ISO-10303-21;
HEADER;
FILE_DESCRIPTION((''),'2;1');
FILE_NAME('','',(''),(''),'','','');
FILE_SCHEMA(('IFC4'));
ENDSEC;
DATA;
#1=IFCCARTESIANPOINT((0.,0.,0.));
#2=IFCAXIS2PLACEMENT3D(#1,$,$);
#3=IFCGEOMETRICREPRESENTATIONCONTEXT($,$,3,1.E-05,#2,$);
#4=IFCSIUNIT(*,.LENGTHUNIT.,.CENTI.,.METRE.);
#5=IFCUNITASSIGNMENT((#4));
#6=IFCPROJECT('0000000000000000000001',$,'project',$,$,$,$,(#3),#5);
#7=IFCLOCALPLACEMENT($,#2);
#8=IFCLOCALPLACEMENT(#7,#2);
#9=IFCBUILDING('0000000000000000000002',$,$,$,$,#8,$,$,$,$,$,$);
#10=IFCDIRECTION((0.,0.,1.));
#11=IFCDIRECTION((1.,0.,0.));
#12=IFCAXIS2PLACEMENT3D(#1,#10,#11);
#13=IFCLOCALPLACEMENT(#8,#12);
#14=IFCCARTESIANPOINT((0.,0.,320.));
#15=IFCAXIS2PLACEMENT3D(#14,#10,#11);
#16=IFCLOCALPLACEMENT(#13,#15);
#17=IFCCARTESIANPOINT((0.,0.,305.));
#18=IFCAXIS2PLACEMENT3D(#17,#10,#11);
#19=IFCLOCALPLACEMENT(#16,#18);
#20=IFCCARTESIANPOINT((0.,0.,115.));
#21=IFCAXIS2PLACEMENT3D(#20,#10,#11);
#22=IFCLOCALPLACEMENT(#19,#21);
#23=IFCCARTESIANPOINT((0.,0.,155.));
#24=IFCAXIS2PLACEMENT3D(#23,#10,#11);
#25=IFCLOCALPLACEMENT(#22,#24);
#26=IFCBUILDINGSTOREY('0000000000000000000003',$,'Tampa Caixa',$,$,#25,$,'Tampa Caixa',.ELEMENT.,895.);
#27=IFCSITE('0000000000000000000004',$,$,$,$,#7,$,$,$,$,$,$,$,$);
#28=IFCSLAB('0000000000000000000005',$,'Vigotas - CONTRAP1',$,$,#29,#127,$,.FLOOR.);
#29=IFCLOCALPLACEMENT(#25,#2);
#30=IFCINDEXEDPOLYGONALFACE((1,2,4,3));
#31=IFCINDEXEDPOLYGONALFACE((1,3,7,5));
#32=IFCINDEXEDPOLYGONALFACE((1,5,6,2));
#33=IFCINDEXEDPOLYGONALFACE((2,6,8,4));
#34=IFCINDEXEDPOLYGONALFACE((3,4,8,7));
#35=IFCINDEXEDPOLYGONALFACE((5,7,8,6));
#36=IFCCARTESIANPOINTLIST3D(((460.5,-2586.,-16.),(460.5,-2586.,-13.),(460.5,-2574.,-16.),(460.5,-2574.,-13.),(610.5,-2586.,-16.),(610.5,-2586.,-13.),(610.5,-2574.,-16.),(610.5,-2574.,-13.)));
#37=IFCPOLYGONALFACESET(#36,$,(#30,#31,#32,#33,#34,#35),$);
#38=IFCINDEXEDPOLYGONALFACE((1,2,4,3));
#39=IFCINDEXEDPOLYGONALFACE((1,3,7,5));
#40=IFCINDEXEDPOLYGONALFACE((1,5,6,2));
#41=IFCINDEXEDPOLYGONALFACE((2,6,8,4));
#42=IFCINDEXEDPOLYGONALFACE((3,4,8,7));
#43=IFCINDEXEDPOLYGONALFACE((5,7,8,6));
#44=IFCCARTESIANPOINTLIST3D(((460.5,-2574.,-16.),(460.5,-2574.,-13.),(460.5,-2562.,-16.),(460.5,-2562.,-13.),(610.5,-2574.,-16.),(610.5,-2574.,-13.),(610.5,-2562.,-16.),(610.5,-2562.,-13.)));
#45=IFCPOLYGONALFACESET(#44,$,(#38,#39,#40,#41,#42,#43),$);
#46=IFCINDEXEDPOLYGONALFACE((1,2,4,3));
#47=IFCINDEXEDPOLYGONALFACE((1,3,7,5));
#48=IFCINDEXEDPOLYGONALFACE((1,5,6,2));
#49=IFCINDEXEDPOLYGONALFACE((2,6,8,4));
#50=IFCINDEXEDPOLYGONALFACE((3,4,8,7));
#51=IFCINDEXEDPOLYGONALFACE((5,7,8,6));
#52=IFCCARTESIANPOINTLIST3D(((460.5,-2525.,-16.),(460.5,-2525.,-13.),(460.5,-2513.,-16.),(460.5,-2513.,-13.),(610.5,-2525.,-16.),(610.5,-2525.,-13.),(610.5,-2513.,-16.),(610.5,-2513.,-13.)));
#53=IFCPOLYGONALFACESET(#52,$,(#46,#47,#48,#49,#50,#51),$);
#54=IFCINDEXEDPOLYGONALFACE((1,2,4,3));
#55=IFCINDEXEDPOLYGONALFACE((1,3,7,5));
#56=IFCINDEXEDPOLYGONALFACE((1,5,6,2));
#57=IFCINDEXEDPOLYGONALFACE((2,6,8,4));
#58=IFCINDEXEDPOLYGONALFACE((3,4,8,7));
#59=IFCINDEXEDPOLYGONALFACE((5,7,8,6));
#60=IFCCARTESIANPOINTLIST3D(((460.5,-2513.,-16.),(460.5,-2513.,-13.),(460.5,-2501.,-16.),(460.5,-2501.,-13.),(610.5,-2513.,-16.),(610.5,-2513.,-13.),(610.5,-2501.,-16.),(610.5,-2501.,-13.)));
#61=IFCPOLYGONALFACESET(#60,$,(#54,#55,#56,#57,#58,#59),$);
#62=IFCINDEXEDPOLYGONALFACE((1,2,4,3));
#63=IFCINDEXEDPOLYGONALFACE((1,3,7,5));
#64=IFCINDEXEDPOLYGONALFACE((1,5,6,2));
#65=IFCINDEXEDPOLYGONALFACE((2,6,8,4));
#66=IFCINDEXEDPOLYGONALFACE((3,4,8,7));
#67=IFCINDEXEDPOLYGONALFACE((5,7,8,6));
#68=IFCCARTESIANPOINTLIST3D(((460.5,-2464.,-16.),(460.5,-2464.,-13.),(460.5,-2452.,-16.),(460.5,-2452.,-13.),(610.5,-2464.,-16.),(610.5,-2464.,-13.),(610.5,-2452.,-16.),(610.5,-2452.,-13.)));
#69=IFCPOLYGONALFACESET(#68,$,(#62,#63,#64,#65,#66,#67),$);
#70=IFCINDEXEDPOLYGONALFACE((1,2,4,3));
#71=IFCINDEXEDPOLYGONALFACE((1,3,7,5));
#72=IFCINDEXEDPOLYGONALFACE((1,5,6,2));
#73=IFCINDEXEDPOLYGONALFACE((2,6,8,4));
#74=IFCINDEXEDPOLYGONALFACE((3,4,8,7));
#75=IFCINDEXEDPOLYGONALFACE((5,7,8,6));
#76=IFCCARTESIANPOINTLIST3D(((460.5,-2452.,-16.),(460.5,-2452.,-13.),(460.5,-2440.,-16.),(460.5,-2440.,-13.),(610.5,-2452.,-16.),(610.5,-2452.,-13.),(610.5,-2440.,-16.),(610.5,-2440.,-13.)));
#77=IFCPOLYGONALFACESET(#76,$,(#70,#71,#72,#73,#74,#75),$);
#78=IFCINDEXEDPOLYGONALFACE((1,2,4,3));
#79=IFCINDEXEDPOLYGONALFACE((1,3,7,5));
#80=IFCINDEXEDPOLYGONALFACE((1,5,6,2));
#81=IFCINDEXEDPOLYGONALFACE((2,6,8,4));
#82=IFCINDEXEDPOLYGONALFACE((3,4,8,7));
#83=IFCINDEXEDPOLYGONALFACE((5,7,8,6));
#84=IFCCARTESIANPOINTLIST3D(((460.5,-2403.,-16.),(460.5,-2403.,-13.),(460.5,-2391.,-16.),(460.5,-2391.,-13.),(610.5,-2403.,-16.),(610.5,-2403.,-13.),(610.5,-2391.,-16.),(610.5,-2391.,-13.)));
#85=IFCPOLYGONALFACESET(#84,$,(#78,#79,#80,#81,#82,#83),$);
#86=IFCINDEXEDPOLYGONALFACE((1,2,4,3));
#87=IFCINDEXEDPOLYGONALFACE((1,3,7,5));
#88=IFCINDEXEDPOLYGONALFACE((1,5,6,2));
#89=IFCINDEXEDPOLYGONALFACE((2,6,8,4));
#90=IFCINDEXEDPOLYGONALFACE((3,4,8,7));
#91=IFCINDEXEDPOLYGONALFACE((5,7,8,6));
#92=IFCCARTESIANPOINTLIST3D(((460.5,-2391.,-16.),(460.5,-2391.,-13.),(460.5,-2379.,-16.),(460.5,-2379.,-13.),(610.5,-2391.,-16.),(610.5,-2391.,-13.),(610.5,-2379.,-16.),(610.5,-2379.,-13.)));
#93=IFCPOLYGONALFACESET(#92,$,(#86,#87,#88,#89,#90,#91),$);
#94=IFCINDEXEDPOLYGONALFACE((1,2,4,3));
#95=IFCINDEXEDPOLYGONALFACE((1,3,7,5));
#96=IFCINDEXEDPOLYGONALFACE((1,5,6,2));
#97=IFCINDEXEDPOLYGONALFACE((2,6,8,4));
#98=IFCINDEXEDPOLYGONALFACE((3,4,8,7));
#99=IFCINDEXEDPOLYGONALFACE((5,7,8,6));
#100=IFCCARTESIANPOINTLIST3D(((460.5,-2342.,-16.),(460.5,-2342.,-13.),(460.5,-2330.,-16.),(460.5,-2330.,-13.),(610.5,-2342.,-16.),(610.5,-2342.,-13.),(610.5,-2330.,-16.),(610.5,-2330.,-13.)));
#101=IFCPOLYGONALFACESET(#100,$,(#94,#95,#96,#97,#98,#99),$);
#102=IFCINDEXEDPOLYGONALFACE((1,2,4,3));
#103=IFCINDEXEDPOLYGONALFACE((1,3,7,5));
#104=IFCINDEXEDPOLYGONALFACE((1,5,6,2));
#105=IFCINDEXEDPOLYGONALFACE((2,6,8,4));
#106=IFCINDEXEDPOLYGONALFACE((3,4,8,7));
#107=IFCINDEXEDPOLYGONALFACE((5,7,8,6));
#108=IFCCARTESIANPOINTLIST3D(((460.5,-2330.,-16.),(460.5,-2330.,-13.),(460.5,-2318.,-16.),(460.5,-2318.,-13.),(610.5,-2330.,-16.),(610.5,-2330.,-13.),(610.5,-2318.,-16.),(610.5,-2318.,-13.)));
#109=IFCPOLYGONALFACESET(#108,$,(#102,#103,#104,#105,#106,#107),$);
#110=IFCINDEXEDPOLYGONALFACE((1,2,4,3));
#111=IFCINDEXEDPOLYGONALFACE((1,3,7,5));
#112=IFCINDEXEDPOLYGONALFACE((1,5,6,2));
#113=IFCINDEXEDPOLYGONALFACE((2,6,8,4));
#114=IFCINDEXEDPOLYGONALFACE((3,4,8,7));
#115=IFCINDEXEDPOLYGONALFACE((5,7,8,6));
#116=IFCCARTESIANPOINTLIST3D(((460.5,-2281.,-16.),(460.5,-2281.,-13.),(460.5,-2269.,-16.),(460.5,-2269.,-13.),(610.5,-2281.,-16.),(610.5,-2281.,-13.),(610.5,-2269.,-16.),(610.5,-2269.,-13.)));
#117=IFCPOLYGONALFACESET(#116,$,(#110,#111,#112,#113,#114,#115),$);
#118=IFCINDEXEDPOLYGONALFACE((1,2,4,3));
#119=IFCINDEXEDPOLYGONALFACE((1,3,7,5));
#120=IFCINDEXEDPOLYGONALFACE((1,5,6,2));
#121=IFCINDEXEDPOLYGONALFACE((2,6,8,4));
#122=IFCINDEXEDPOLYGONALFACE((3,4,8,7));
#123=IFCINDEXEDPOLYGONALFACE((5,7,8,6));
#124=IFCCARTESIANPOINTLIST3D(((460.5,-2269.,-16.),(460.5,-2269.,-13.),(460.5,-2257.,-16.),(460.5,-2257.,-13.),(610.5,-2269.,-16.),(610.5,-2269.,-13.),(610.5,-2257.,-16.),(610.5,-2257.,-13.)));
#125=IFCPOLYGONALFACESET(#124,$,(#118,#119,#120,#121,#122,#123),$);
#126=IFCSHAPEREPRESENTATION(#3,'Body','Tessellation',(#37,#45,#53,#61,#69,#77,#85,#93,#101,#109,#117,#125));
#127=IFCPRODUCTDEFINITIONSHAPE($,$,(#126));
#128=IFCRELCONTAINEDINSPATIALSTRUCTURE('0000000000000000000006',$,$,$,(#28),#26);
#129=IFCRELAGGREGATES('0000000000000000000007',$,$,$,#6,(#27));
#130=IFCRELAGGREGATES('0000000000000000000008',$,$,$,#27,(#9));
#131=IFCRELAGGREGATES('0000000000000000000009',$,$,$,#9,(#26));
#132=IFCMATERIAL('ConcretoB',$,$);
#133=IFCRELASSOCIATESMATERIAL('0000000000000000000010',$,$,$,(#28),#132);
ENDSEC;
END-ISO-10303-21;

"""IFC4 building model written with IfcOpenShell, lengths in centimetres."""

from ifc_helpers import new_model, si_unit, frame, origin, origin_with_axes, place, context, project, spatial, polyline, outline, extrude, material, element, save


model = new_model("IFC4")

# Units and contexts
context_of_model = context(None, 3, precision=1e-05, world=origin())
ifc_project = project(units=[si_unit("LENGTHUNIT", "METRE", prefix="CENTI")], contexts=[context_of_model])

# Site, building, storey
site_placement = place(None, origin())
site = spatial("IfcSite", under=ifc_project, at=site_placement)
building_placement = place(site_placement, origin())
building = spatial("IfcBuilding", under=site, at=building_placement)
placement_1 = place(building_placement, origin_with_axes())
placement_2 = place(placement_1, frame((0.0, 0.0, 320.0), z_axis=(0.0, 0.0, 1.0), x_axis=(1.0, 0.0, 0.0)))
placement_3 = place(placement_2, frame((0.0, 0.0, 305.0), z_axis=(0.0, 0.0, 1.0), x_axis=(1.0, 0.0, 0.0)))
placement_4 = place(placement_3, frame((0.0, 0.0, 115.0), z_axis=(0.0, 0.0, 1.0), x_axis=(1.0, 0.0, 0.0)))
storey_placement = place(placement_4, frame((0.0, 0.0, 155.0), z_axis=(0.0, 0.0, 1.0), x_axis=(1.0, 0.0, 0.0)))
storey = spatial("IfcBuildingStorey", under=building, at=storey_placement, Name="Tampa Caixa", LongName="Tampa Caixa", CompositionType="ELEMENT", Elevation=895.0)

# Shared definitions
ifc_material = material(Name="ConcretoB")

# Slab
slab_placement = place(storey_placement, frame((535.5, -2421.5, -13.0), z_axis=(0.0, 0.0, 1.0), x_axis=(1.0, 0.0, 0.0)))
element("IfcSlab", 1, at=slab_placement, inside=storey, material=ifc_material, Name="Vigotas - CONTRAP1", PredefinedType="FLOOR", context=context_of_model, shape_type="SolidModel", body=[
    extrude(outline(polyline([(6.0, 1.5), (-6.0, 1.5), (-6.0, -1.5), (6.0, -1.5), (6.0, 1.5), (6.0, 1.5)])), frame((-75.0, -158.5, -1.5), z_axis=(1.0, 0.0, 0.0), x_axis=(0.0, -1.0, 0.0)), (0.0, 0.0, 1.0), 150.0),
    extrude(outline(polyline([(6.0, 1.5), (-6.0, 1.5), (-6.0, -1.5), (6.0, -1.5), (6.0, 1.5), (6.0, 1.5)])), frame((-75.0, -146.5, -1.5), z_axis=(1.0, 0.0, 0.0), x_axis=(0.0, -1.0, 0.0)), (0.0, 0.0, 1.0), 150.0),
    extrude(outline(polyline([(6.0, 1.5), (-6.0, 1.5), (-6.0, -1.5), (6.0, -1.5), (6.0, 1.5), (6.0, 1.5)])), frame((-75.0, -97.5, -1.5), z_axis=(1.0, 0.0, 0.0), x_axis=(0.0, -1.0, 0.0)), (0.0, 0.0, 1.0), 150.0),
    extrude(outline(polyline([(6.0, 1.5), (-6.0, 1.5), (-6.0, -1.5), (6.0, -1.5), (6.0, 1.5), (6.0, 1.5)])), frame((-75.0, -85.5, -1.5), z_axis=(1.0, 0.0, 0.0), x_axis=(0.0, -1.0, 0.0)), (0.0, 0.0, 1.0), 150.0),
    extrude(outline(polyline([(6.0, 1.5), (-6.0, 1.5), (-6.0, -1.5), (6.0, -1.5), (6.0, 1.5), (6.0, 1.5)])), frame((-75.0, -36.5, -1.5), z_axis=(1.0, 0.0, 0.0), x_axis=(0.0, -1.0, 0.0)), (0.0, 0.0, 1.0), 150.0),
    extrude(outline(polyline([(6.0, 1.5), (-6.0, 1.5), (-6.0, -1.5), (6.0, -1.5), (6.0, 1.5), (6.0, 1.5)])), frame((-75.0, -24.5, -1.5), z_axis=(1.0, 0.0, 0.0), x_axis=(0.0, -1.0, 0.0)), (0.0, 0.0, 1.0), 150.0),
    extrude(outline(polyline([(6.0, 1.5), (-6.0, 1.5), (-6.0, -1.5), (6.0, -1.5), (6.0, 1.5), (6.0, 1.5)])), frame((-75.0, 24.5, -1.5), z_axis=(1.0, 0.0, 0.0), x_axis=(0.0, -1.0, 0.0)), (0.0, 0.0, 1.0), 150.0),
    extrude(outline(polyline([(6.0, 1.5), (-6.0, 1.5), (-6.0, -1.5), (6.0, -1.5), (6.0, 1.5), (6.0, 1.5)])), frame((-75.0, 36.5, -1.5), z_axis=(1.0, 0.0, 0.0), x_axis=(0.0, -1.0, 0.0)), (0.0, 0.0, 1.0), 150.0),
    extrude(outline(polyline([(6.0, 1.5), (-6.0, 1.5), (-6.0, -1.5), (6.0, -1.5), (6.0, 1.5), (6.0, 1.5)])), frame((-75.0, 85.5, -1.5), z_axis=(1.0, 0.0, 0.0), x_axis=(0.0, -1.0, 0.0)), (0.0, 0.0, 1.0), 150.0),
    extrude(outline(polyline([(6.0, 1.5), (-6.0, 1.5), (-6.0, -1.5), (6.0, -1.5), (6.0, 1.5), (6.0, 1.5)])), frame((-75.0, 97.5, -1.5), z_axis=(1.0, 0.0, 0.0), x_axis=(0.0, -1.0, 0.0)), (0.0, 0.0, 1.0), 150.0),
    extrude(outline(polyline([(6.0, 1.5), (-6.0, 1.5), (-6.0, -1.5), (6.0, -1.5), (6.0, 1.5), (6.0, 1.5)])), frame((-75.0, 146.5, -1.5), z_axis=(1.0, 0.0, 0.0), x_axis=(0.0, -1.0, 0.0)), (0.0, 0.0, 1.0), 150.0),
    extrude(outline(polyline([(6.0, 1.5), (-6.0, 1.5), (-6.0, -1.5), (6.0, -1.5), (6.0, 1.5), (6.0, 1.5)])), frame((-75.0, 158.5, -1.5), z_axis=(1.0, 0.0, 0.0), x_axis=(0.0, -1.0, 0.0)), (0.0, 0.0, 1.0), 150.0),
])

save(model, "model.ifc")
